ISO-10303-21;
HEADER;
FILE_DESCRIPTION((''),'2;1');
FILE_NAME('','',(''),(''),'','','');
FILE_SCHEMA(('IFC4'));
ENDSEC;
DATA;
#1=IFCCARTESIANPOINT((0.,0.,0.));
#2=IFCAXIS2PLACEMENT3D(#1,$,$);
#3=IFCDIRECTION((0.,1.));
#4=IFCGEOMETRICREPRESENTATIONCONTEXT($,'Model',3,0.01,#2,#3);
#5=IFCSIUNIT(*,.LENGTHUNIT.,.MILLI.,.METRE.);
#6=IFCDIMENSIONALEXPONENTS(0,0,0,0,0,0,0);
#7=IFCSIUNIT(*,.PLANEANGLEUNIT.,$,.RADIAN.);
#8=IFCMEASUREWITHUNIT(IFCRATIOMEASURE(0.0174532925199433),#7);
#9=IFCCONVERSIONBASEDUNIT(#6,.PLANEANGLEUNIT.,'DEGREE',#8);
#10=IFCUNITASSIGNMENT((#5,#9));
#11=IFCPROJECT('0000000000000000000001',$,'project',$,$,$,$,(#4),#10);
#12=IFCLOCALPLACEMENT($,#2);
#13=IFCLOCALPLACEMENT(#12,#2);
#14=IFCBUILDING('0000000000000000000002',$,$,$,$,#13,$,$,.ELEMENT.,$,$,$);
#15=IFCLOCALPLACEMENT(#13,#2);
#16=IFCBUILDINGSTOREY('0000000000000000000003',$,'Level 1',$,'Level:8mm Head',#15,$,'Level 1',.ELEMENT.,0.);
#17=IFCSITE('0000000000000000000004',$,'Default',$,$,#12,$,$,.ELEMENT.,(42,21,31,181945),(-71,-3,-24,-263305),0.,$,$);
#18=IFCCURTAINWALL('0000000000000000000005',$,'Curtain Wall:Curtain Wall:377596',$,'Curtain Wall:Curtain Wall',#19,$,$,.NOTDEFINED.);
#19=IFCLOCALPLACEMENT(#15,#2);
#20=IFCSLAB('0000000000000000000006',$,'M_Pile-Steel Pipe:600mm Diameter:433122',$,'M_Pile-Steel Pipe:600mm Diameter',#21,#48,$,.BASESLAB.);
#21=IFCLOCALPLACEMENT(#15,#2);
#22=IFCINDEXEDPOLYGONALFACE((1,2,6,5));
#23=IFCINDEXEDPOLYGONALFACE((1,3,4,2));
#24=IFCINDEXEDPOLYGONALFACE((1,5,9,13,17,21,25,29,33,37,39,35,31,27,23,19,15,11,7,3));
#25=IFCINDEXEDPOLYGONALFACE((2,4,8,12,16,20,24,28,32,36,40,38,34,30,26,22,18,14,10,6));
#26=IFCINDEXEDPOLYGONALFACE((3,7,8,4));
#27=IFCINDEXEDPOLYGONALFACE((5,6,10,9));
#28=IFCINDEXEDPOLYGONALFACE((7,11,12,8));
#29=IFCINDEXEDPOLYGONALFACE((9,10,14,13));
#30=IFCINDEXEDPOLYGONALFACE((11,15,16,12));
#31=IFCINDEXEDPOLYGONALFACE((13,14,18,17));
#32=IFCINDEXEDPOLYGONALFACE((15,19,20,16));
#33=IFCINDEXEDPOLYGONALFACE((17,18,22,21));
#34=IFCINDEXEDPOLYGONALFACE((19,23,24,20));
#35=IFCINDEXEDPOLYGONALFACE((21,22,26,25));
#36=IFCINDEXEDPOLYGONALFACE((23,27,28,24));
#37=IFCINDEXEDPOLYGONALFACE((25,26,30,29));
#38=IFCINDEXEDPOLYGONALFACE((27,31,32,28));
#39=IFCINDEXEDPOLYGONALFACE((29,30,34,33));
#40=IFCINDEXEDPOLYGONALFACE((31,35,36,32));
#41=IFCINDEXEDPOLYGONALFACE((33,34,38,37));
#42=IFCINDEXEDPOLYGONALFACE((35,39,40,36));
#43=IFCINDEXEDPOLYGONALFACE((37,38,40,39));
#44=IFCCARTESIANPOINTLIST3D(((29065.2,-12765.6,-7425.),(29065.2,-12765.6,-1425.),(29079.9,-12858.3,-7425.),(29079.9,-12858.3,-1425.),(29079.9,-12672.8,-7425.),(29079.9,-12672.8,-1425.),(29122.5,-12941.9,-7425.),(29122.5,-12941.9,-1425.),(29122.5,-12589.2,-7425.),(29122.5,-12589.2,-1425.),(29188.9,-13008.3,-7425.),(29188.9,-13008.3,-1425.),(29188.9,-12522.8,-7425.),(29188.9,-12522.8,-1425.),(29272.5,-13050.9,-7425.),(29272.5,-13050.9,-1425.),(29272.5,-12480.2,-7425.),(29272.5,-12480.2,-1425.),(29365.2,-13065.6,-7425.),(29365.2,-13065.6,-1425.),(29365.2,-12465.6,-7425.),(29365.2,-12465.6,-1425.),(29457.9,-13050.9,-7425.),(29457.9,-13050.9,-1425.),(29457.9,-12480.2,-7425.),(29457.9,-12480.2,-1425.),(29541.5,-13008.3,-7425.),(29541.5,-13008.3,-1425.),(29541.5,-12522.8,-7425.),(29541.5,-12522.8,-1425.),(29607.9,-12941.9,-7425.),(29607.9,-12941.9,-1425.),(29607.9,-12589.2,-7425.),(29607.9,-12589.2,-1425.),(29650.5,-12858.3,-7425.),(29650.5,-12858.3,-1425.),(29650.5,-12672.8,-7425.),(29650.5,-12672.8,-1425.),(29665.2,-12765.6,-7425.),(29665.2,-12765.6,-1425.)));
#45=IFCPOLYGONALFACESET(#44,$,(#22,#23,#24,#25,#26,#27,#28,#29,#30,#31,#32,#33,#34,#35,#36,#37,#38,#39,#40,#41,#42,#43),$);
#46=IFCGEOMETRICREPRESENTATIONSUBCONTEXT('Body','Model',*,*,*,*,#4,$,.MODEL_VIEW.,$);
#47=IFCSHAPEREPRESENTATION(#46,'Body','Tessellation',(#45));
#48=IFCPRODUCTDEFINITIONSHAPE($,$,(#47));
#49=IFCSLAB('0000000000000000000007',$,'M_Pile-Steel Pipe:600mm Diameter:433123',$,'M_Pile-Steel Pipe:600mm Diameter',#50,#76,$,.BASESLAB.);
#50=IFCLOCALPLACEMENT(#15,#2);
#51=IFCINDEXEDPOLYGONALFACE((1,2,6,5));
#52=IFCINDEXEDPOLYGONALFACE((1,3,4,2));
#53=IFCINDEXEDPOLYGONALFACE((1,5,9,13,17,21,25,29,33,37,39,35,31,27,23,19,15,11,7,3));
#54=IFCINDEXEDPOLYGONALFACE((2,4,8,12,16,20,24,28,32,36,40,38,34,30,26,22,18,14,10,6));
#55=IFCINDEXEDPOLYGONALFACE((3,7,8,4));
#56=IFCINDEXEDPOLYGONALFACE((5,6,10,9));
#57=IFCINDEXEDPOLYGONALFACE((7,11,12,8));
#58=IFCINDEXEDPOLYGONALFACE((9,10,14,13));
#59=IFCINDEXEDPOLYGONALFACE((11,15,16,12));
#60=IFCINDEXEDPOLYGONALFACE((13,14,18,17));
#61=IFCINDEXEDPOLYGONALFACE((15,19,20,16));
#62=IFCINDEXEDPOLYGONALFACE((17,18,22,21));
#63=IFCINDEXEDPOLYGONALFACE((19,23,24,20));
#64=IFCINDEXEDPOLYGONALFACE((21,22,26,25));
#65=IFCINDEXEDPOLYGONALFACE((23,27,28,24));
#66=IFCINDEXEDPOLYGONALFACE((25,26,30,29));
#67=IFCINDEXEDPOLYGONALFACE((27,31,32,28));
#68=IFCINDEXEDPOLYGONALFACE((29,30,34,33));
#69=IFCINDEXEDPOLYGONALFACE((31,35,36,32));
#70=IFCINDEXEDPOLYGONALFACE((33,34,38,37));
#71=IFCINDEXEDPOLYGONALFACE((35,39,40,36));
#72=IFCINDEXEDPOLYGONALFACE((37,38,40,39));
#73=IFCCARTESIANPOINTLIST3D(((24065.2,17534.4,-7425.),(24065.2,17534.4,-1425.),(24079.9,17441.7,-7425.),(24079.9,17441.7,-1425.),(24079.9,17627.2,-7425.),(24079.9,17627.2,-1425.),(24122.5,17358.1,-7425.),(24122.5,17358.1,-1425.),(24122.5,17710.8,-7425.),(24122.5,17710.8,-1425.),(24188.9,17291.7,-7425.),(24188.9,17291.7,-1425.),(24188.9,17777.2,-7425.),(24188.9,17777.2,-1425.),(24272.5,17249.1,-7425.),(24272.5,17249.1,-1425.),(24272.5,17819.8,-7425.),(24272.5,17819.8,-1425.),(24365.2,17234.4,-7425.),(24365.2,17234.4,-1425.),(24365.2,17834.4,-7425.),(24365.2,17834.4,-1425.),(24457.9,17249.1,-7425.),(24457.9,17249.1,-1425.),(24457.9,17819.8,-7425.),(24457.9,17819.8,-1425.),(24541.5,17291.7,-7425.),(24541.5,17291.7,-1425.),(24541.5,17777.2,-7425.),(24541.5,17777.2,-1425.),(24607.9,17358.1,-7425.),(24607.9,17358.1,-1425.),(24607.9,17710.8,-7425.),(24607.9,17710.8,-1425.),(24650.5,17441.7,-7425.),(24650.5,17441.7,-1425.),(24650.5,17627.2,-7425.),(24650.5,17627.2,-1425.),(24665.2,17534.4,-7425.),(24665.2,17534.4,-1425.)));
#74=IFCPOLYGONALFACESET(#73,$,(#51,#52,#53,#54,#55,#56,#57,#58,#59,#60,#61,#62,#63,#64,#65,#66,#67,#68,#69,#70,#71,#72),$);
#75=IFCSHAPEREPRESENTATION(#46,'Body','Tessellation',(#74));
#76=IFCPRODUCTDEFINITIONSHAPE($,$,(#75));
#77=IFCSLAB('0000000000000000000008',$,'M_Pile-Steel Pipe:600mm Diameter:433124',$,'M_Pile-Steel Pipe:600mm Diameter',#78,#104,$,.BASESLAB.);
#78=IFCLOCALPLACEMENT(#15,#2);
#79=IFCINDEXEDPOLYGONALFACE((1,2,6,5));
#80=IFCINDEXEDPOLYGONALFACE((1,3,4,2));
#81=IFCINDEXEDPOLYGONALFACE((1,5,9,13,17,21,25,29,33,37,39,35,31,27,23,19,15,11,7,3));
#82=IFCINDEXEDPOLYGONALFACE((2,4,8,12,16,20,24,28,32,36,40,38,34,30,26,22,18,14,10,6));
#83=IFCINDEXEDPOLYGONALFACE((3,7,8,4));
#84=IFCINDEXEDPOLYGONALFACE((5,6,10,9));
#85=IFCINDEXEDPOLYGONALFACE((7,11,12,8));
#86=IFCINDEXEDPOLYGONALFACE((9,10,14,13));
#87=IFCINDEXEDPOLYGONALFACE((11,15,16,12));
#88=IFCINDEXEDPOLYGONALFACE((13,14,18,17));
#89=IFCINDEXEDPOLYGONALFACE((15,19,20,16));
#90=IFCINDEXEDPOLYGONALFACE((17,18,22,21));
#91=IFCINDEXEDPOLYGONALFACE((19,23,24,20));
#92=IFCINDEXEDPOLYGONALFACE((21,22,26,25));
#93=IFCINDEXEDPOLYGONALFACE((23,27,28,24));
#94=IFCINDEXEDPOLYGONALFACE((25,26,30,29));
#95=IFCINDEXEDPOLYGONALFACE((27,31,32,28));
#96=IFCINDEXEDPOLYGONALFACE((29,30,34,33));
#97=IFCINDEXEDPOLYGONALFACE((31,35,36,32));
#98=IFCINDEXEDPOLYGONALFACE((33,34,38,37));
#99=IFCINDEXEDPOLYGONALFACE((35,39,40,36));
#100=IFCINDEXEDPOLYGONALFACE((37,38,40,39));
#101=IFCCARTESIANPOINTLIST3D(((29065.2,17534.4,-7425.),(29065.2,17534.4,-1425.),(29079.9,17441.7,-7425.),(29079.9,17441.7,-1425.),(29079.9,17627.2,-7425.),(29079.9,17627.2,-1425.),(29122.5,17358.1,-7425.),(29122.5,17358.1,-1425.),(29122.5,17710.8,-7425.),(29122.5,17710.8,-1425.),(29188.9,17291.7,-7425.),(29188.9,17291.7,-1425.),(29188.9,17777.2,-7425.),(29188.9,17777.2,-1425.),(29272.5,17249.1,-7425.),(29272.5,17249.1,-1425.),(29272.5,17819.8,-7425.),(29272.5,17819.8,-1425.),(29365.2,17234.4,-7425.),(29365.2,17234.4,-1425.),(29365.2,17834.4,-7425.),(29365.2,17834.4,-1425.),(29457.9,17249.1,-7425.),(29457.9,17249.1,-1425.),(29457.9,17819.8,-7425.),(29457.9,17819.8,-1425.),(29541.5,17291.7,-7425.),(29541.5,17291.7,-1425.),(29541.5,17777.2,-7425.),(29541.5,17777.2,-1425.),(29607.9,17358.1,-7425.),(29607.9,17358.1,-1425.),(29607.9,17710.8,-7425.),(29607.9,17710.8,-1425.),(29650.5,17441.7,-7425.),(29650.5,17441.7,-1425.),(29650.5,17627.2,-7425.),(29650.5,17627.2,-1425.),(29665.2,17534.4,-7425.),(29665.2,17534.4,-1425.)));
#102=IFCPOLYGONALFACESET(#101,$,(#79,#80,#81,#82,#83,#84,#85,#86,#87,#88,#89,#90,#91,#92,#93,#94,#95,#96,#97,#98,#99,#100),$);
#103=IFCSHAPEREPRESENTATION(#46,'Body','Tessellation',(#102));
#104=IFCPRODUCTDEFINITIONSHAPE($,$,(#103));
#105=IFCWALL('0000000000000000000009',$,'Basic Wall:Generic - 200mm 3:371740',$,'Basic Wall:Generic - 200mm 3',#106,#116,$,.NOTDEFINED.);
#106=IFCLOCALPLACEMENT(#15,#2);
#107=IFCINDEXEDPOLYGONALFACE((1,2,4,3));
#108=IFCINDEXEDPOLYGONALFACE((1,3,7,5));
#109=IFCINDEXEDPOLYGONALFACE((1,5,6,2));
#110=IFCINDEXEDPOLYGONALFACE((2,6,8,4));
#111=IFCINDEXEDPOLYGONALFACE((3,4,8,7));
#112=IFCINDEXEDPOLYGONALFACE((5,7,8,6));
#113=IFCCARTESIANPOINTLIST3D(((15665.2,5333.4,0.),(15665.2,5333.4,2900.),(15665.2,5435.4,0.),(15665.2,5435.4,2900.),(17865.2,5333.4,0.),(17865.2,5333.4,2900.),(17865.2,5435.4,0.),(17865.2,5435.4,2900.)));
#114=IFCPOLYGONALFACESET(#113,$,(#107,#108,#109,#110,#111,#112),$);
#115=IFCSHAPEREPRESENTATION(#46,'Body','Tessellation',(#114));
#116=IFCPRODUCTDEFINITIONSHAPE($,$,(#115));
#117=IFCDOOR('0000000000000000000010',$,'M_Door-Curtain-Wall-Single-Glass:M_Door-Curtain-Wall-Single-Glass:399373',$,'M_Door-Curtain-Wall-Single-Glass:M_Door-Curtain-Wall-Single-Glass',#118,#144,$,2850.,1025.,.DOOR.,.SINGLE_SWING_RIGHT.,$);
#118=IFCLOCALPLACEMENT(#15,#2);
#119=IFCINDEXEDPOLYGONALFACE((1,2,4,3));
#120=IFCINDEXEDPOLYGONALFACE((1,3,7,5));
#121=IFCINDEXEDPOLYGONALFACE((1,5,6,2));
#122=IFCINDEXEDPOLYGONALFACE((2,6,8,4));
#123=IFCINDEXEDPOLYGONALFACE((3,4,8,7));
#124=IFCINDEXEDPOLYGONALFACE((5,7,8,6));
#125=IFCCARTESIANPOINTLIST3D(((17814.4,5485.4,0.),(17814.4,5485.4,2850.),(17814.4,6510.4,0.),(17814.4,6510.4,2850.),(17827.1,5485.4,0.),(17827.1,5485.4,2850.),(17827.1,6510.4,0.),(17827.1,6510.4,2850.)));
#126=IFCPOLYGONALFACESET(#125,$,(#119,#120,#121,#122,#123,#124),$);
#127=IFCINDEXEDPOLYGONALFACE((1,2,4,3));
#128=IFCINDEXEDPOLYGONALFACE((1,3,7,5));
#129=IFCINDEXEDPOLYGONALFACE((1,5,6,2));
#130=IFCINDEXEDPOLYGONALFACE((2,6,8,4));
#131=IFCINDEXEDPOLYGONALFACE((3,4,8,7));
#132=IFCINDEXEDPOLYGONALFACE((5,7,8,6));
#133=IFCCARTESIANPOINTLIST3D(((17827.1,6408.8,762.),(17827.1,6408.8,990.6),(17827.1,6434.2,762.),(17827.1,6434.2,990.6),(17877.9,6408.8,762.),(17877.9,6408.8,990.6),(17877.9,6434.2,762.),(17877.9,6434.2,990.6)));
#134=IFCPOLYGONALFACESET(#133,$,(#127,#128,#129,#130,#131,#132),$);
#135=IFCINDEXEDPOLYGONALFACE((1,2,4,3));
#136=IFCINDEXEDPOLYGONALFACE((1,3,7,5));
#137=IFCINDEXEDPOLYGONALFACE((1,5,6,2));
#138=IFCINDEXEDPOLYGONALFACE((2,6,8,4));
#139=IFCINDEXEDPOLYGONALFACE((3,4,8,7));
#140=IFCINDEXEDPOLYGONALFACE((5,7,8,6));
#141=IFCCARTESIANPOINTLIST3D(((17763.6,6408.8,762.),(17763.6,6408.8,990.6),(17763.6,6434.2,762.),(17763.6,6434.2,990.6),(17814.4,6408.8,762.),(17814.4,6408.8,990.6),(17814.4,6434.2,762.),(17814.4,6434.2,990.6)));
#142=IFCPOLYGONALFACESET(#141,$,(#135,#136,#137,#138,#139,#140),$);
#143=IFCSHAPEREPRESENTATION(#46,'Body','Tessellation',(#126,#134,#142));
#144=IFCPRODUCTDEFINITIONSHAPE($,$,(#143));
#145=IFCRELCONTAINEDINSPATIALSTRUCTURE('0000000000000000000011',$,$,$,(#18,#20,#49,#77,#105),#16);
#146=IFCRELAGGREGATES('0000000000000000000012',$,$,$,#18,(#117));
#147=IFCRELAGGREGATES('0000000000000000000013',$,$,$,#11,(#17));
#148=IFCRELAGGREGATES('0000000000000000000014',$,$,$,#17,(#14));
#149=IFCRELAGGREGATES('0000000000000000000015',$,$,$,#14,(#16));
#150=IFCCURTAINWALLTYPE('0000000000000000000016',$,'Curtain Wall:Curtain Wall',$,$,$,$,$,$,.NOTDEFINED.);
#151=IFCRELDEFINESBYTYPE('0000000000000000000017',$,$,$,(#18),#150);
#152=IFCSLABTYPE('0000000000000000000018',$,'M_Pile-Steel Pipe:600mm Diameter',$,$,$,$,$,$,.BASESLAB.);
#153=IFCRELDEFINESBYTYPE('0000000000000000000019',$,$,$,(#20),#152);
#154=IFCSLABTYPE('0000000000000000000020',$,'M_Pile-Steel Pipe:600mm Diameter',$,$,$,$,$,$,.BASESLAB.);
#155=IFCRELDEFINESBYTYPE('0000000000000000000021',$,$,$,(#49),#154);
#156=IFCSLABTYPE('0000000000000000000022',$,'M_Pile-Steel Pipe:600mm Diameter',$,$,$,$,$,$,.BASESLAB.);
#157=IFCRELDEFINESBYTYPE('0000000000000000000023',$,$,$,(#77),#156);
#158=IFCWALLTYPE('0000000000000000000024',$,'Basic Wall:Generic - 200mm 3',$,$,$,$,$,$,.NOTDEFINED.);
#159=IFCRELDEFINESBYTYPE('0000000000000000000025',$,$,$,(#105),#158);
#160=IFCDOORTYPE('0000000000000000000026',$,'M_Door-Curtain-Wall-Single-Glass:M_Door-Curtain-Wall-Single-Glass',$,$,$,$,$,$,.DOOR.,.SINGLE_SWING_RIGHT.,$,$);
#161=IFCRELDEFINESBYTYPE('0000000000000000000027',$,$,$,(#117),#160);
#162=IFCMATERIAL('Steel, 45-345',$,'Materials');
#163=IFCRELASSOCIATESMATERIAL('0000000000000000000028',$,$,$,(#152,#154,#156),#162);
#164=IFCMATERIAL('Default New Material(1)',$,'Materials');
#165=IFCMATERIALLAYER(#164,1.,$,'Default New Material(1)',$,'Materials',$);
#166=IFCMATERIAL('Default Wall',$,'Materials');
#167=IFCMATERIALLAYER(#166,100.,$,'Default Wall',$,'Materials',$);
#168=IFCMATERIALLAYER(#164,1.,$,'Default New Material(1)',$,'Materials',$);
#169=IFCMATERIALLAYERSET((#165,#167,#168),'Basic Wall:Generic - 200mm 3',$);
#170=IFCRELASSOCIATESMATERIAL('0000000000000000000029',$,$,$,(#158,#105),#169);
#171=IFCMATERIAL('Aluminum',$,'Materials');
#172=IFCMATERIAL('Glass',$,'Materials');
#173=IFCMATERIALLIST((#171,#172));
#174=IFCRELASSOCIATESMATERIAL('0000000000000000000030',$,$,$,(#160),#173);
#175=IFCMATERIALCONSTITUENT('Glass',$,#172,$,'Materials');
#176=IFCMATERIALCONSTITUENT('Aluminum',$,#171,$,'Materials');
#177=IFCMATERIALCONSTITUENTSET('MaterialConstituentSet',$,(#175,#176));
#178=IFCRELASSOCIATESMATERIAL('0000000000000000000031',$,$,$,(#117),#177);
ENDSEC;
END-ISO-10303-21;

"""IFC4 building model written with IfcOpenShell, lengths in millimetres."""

from ifc_helpers import new_model, entity, si_unit, converted_unit, direction, frame, origin, place, context, subcontext, project, spatial, indexed_curve, outline, extrude, source, transform, mapped, material, material_list, layer, layer_set, constituent, constituent_set, type_object, type_shapes, element, aggregate, save


model = new_model("IFC4")

# Units and contexts
model_context = context("Model", 3, precision=0.01, world=origin(), true_north=direction((0.0, 1.0)))
body_context = subcontext(model_context, "Body", "Model", "MODEL_VIEW")
ifc_project = project(units=[si_unit("LENGTHUNIT", "METRE", prefix="MILLI"), converted_unit("PLANEANGLEUNIT", "DEGREE", entity("IfcRatioMeasure", 0.0174532925199433), si_unit("PLANEANGLEUNIT", "RADIAN"), dimensions=[0, 0, 0, 0, 0, 0, 0])], contexts=[model_context])

# Site, building, storey
site_placement = place(None, origin())
site = spatial("IfcSite", under=ifc_project, at=site_placement, Name="Default", CompositionType="ELEMENT", RefLatitude=(42, 21, 31, 181945), RefLongitude=(-71, -3, -24, -263305), RefElevation=0.0)
building_placement = place(site_placement, origin())
building = spatial("IfcBuilding", under=site, at=building_placement, CompositionType="ELEMENT")
storey_placement = place(building_placement, origin())
storey = spatial("IfcBuildingStorey", under=building, at=storey_placement, Name="Level 1", ObjectType="Level:8mm Head", LongName="Level 1", CompositionType="ELEMENT", Elevation=0.0)

# Curtain wall
curtain_wall_type_1 = type_object("IfcCurtainWallType", Name="Curtain Wall:Curtain Wall", PredefinedType="NOTDEFINED")
curtain_wall_1_placement = place(storey_placement, origin())
curtain_wall_1 = element("IfcCurtainWall", 1, at=curtain_wall_1_placement, inside=storey, type_object=curtain_wall_type_1, Name="Curtain Wall:Curtain Wall:377596", ObjectType="Curtain Wall:Curtain Wall", PredefinedType="NOTDEFINED")

# Shared definitions
ifc_material_1 = material(Name="Glass", Category="Materials")

# Slabs
ifc_material_2 = material(Name="Steel, 45-345", Category="Materials")
slab_type_1 = type_object("IfcSlabType", Name="M_Pile-Steel Pipe:600mm Diameter", PredefinedType="BASESLAB", material=ifc_material_2)
slab_1_placement = place(building_placement, origin())
element("IfcSlab", 2, at=slab_1_placement, inside=storey, type_object=slab_type_1, Name="M_Pile-Steel Pipe:600mm Diameter:433122", ObjectType="M_Pile-Steel Pipe:600mm Diameter", PredefinedType="BASESLAB", context=body_context, shape_type="SweptSolid", body=[
    extrude(outline(indexed_curve([(300.0, 0.0), (285.3, 92.7), (242.7, 176.3), (176.3, 242.7), (92.7, 285.3), (0.0, 300.0), (-92.7, 285.3), (-176.3, 242.7), (-242.7, 176.3), (-285.3, 92.7), (-300.0, 0.0), (-285.3, -92.7), (-242.7, -176.3), (-176.3, -242.7), (-92.7, -285.3), (0.0, -300.0), (92.7, -285.3), (176.3, -242.7), (242.7, -176.3), (285.3, -92.7), (300.0, 0.0)], self_intersect=False)), frame((29365.2, -12765.6, -7425.0)), (0.0, 0.0, 1.0), 6000.0),
])
slab_type_2 = type_object("IfcSlabType", Name="M_Pile-Steel Pipe:600mm Diameter", PredefinedType="BASESLAB", material=ifc_material_2)
slab_2_placement = place(building_placement, origin())
element("IfcSlab", 3, at=slab_2_placement, inside=storey, type_object=slab_type_2, Name="M_Pile-Steel Pipe:600mm Diameter:433123", ObjectType="M_Pile-Steel Pipe:600mm Diameter", PredefinedType="BASESLAB", context=body_context, shape_type="SweptSolid", body=[
    extrude(outline(indexed_curve([(300.0, 0.0), (285.3, 92.7), (242.7, 176.3), (176.3, 242.7), (92.7, 285.3), (0.0, 300.0), (-92.7, 285.3), (-176.3, 242.7), (-242.7, 176.3), (-285.3, 92.7), (-300.0, 0.0), (-285.3, -92.7), (-242.7, -176.3), (-176.3, -242.7), (-92.7, -285.3), (0.0, -300.0), (92.7, -285.3), (176.3, -242.7), (242.7, -176.3), (285.3, -92.7), (300.0, 0.0)], self_intersect=False)), frame((24365.2, 17534.4, -7425.0)), (0.0, 0.0, 1.0), 6000.0),
])
slab_type_3 = type_object("IfcSlabType", Name="M_Pile-Steel Pipe:600mm Diameter", PredefinedType="BASESLAB", material=ifc_material_2)
slab_3_placement = place(building_placement, origin())
element("IfcSlab", 4, at=slab_3_placement, inside=storey, type_object=slab_type_3, Name="M_Pile-Steel Pipe:600mm Diameter:433124", ObjectType="M_Pile-Steel Pipe:600mm Diameter", PredefinedType="BASESLAB", context=body_context, shape_type="SweptSolid", body=[
    extrude(outline(indexed_curve([(300.0, 0.0), (285.3, 92.7), (242.7, 176.3), (176.3, 242.7), (92.7, 285.3), (0.0, 300.0), (-92.7, 285.3), (-176.3, 242.7), (-242.7, 176.3), (-285.3, 92.7), (-300.0, 0.0), (-285.3, -92.7), (-242.7, -176.3), (-176.3, -242.7), (-92.7, -285.3), (0.0, -300.0), (92.7, -285.3), (176.3, -242.7), (242.7, -176.3), (285.3, -92.7), (300.0, 0.0)], self_intersect=False)), frame((29365.2, 17534.4, -7425.0)), (0.0, 0.0, 1.0), 6000.0),
])

# Shared definitions
ifc_material_3 = material(Name="Aluminum", Category="Materials")

# Wall
ifc_material_4 = material(Name="Default New Material(1)", Category="Materials")
ifc_layer_1 = layer(ifc_material_4, 1.0, Name="Default New Material(1)", Category="Materials")
ifc_material_5 = material(Name="Default Wall", Category="Materials")
ifc_layer_2 = layer(ifc_material_5, 100.0, Name="Default Wall", Category="Materials")
ifc_layer_3 = layer(ifc_material_4, 1.0, Name="Default New Material(1)", Category="Materials")
ifc_layer_set = layer_set([ifc_layer_1, ifc_layer_2, ifc_layer_3], Name="Basic Wall:Generic - 200mm 3")
wall_type = type_object("IfcWallType", Name="Basic Wall:Generic - 200mm 3", PredefinedType="NOTDEFINED", material=ifc_layer_set)
wall_placement = place(storey_placement, frame((15665.2, 5384.4, 0.0)))
element("IfcWall", 5, at=wall_placement, inside=storey, type_object=wall_type, material=ifc_layer_set, Name="Basic Wall:Generic - 200mm 3:371740", ObjectType="Basic Wall:Generic - 200mm 3", PredefinedType="NOTDEFINED", context=body_context, shape_type="SweptSolid", body=[
    extrude(outline(indexed_curve([(2200.0, 51.0), (0.0, 51.0), (0.0, -51.0), (2200.0, -51.0), (2200.0, 51.0)], self_intersect=False)), origin(), (0.0, 0.0, 1.0), 2900.0),
])

# Door
ifc_constituent_1 = constituent(ifc_material_1, Name="Glass", Category="Materials")
ifc_constituent_2 = constituent(ifc_material_3, Name="Aluminum", Category="Materials")
ifc_constituent_set_1 = constituent_set(constituents=[ifc_constituent_1, ifc_constituent_2], Name="MaterialConstituentSet")
ifc_material_list_1 = material_list([ifc_material_3, ifc_material_1])
door_type_1 = type_object("IfcDoorType", Name="M_Door-Curtain-Wall-Single-Glass:M_Door-Curtain-Wall-Single-Glass", OperationType="SINGLE_SWING_RIGHT", PredefinedType="DOOR", material=ifc_material_list_1)
shared_shape_1 = source(origin(), body_context, "Body", "SweptSolid", [
    extrude(outline(indexed_curve([(-6.4, -512.5), (6.4, -512.5), (6.4, 512.5), (-6.4, 512.5), (-6.4, -512.5)], self_intersect=False)), frame((0.0, -44.5, 0.0), z_axis=(0.0, 0.0, 1.0), x_axis=(0.0, 1.0, 0.0)), (0.0, 0.0, 1.0), 2850.0),
    extrude(outline(indexed_curve([(-12.7, -25.4), (12.7, -25.4), (12.7, 25.4), (-12.7, 25.4), (-12.7, -25.4)], self_intersect=False)), frame((-423.6, -12.7, 762.0), z_axis=(0.0, 0.0, 1.0), x_axis=(-1.0, 0.0, 0.0)), (0.0, 0.0, 1.0), 228.6),
    extrude(outline(indexed_curve([(-12.7, -25.4), (12.7, -25.4), (12.7, 25.4), (-12.7, 25.4), (-12.7, -25.4)], self_intersect=False)), frame((-423.6, -76.2, 762.0)), (0.0, 0.0, 1.0), 228.6),
])
type_shapes(door_type_1, [shared_shape_1])
door_1_placement = place(curtain_wall_1_placement, frame((17865.2, 5997.9, 0.0), z_axis=(0.0, 0.0, 1.0), x_axis=(0.0, -1.0, 0.0)))
door_1 = element("IfcDoor", 6, at=door_1_placement, type_object=door_type_1, material=ifc_constituent_set_1, Name="M_Door-Curtain-Wall-Single-Glass:M_Door-Curtain-Wall-Single-Glass:399373", ObjectType="M_Door-Curtain-Wall-Single-Glass:M_Door-Curtain-Wall-Single-Glass", OperationType="SINGLE_SWING_RIGHT", OverallHeight=2850.0, OverallWidth=1025.0, PredefinedType="DOOR", context=body_context, shape_type="MappedRepresentation", body=[
    mapped(shared_shape_1, transform((0.0, 0.0, 0.0), scale=1.0)),
])
aggregate(curtain_wall_1, [door_1])

save(model, "model.ifc")
